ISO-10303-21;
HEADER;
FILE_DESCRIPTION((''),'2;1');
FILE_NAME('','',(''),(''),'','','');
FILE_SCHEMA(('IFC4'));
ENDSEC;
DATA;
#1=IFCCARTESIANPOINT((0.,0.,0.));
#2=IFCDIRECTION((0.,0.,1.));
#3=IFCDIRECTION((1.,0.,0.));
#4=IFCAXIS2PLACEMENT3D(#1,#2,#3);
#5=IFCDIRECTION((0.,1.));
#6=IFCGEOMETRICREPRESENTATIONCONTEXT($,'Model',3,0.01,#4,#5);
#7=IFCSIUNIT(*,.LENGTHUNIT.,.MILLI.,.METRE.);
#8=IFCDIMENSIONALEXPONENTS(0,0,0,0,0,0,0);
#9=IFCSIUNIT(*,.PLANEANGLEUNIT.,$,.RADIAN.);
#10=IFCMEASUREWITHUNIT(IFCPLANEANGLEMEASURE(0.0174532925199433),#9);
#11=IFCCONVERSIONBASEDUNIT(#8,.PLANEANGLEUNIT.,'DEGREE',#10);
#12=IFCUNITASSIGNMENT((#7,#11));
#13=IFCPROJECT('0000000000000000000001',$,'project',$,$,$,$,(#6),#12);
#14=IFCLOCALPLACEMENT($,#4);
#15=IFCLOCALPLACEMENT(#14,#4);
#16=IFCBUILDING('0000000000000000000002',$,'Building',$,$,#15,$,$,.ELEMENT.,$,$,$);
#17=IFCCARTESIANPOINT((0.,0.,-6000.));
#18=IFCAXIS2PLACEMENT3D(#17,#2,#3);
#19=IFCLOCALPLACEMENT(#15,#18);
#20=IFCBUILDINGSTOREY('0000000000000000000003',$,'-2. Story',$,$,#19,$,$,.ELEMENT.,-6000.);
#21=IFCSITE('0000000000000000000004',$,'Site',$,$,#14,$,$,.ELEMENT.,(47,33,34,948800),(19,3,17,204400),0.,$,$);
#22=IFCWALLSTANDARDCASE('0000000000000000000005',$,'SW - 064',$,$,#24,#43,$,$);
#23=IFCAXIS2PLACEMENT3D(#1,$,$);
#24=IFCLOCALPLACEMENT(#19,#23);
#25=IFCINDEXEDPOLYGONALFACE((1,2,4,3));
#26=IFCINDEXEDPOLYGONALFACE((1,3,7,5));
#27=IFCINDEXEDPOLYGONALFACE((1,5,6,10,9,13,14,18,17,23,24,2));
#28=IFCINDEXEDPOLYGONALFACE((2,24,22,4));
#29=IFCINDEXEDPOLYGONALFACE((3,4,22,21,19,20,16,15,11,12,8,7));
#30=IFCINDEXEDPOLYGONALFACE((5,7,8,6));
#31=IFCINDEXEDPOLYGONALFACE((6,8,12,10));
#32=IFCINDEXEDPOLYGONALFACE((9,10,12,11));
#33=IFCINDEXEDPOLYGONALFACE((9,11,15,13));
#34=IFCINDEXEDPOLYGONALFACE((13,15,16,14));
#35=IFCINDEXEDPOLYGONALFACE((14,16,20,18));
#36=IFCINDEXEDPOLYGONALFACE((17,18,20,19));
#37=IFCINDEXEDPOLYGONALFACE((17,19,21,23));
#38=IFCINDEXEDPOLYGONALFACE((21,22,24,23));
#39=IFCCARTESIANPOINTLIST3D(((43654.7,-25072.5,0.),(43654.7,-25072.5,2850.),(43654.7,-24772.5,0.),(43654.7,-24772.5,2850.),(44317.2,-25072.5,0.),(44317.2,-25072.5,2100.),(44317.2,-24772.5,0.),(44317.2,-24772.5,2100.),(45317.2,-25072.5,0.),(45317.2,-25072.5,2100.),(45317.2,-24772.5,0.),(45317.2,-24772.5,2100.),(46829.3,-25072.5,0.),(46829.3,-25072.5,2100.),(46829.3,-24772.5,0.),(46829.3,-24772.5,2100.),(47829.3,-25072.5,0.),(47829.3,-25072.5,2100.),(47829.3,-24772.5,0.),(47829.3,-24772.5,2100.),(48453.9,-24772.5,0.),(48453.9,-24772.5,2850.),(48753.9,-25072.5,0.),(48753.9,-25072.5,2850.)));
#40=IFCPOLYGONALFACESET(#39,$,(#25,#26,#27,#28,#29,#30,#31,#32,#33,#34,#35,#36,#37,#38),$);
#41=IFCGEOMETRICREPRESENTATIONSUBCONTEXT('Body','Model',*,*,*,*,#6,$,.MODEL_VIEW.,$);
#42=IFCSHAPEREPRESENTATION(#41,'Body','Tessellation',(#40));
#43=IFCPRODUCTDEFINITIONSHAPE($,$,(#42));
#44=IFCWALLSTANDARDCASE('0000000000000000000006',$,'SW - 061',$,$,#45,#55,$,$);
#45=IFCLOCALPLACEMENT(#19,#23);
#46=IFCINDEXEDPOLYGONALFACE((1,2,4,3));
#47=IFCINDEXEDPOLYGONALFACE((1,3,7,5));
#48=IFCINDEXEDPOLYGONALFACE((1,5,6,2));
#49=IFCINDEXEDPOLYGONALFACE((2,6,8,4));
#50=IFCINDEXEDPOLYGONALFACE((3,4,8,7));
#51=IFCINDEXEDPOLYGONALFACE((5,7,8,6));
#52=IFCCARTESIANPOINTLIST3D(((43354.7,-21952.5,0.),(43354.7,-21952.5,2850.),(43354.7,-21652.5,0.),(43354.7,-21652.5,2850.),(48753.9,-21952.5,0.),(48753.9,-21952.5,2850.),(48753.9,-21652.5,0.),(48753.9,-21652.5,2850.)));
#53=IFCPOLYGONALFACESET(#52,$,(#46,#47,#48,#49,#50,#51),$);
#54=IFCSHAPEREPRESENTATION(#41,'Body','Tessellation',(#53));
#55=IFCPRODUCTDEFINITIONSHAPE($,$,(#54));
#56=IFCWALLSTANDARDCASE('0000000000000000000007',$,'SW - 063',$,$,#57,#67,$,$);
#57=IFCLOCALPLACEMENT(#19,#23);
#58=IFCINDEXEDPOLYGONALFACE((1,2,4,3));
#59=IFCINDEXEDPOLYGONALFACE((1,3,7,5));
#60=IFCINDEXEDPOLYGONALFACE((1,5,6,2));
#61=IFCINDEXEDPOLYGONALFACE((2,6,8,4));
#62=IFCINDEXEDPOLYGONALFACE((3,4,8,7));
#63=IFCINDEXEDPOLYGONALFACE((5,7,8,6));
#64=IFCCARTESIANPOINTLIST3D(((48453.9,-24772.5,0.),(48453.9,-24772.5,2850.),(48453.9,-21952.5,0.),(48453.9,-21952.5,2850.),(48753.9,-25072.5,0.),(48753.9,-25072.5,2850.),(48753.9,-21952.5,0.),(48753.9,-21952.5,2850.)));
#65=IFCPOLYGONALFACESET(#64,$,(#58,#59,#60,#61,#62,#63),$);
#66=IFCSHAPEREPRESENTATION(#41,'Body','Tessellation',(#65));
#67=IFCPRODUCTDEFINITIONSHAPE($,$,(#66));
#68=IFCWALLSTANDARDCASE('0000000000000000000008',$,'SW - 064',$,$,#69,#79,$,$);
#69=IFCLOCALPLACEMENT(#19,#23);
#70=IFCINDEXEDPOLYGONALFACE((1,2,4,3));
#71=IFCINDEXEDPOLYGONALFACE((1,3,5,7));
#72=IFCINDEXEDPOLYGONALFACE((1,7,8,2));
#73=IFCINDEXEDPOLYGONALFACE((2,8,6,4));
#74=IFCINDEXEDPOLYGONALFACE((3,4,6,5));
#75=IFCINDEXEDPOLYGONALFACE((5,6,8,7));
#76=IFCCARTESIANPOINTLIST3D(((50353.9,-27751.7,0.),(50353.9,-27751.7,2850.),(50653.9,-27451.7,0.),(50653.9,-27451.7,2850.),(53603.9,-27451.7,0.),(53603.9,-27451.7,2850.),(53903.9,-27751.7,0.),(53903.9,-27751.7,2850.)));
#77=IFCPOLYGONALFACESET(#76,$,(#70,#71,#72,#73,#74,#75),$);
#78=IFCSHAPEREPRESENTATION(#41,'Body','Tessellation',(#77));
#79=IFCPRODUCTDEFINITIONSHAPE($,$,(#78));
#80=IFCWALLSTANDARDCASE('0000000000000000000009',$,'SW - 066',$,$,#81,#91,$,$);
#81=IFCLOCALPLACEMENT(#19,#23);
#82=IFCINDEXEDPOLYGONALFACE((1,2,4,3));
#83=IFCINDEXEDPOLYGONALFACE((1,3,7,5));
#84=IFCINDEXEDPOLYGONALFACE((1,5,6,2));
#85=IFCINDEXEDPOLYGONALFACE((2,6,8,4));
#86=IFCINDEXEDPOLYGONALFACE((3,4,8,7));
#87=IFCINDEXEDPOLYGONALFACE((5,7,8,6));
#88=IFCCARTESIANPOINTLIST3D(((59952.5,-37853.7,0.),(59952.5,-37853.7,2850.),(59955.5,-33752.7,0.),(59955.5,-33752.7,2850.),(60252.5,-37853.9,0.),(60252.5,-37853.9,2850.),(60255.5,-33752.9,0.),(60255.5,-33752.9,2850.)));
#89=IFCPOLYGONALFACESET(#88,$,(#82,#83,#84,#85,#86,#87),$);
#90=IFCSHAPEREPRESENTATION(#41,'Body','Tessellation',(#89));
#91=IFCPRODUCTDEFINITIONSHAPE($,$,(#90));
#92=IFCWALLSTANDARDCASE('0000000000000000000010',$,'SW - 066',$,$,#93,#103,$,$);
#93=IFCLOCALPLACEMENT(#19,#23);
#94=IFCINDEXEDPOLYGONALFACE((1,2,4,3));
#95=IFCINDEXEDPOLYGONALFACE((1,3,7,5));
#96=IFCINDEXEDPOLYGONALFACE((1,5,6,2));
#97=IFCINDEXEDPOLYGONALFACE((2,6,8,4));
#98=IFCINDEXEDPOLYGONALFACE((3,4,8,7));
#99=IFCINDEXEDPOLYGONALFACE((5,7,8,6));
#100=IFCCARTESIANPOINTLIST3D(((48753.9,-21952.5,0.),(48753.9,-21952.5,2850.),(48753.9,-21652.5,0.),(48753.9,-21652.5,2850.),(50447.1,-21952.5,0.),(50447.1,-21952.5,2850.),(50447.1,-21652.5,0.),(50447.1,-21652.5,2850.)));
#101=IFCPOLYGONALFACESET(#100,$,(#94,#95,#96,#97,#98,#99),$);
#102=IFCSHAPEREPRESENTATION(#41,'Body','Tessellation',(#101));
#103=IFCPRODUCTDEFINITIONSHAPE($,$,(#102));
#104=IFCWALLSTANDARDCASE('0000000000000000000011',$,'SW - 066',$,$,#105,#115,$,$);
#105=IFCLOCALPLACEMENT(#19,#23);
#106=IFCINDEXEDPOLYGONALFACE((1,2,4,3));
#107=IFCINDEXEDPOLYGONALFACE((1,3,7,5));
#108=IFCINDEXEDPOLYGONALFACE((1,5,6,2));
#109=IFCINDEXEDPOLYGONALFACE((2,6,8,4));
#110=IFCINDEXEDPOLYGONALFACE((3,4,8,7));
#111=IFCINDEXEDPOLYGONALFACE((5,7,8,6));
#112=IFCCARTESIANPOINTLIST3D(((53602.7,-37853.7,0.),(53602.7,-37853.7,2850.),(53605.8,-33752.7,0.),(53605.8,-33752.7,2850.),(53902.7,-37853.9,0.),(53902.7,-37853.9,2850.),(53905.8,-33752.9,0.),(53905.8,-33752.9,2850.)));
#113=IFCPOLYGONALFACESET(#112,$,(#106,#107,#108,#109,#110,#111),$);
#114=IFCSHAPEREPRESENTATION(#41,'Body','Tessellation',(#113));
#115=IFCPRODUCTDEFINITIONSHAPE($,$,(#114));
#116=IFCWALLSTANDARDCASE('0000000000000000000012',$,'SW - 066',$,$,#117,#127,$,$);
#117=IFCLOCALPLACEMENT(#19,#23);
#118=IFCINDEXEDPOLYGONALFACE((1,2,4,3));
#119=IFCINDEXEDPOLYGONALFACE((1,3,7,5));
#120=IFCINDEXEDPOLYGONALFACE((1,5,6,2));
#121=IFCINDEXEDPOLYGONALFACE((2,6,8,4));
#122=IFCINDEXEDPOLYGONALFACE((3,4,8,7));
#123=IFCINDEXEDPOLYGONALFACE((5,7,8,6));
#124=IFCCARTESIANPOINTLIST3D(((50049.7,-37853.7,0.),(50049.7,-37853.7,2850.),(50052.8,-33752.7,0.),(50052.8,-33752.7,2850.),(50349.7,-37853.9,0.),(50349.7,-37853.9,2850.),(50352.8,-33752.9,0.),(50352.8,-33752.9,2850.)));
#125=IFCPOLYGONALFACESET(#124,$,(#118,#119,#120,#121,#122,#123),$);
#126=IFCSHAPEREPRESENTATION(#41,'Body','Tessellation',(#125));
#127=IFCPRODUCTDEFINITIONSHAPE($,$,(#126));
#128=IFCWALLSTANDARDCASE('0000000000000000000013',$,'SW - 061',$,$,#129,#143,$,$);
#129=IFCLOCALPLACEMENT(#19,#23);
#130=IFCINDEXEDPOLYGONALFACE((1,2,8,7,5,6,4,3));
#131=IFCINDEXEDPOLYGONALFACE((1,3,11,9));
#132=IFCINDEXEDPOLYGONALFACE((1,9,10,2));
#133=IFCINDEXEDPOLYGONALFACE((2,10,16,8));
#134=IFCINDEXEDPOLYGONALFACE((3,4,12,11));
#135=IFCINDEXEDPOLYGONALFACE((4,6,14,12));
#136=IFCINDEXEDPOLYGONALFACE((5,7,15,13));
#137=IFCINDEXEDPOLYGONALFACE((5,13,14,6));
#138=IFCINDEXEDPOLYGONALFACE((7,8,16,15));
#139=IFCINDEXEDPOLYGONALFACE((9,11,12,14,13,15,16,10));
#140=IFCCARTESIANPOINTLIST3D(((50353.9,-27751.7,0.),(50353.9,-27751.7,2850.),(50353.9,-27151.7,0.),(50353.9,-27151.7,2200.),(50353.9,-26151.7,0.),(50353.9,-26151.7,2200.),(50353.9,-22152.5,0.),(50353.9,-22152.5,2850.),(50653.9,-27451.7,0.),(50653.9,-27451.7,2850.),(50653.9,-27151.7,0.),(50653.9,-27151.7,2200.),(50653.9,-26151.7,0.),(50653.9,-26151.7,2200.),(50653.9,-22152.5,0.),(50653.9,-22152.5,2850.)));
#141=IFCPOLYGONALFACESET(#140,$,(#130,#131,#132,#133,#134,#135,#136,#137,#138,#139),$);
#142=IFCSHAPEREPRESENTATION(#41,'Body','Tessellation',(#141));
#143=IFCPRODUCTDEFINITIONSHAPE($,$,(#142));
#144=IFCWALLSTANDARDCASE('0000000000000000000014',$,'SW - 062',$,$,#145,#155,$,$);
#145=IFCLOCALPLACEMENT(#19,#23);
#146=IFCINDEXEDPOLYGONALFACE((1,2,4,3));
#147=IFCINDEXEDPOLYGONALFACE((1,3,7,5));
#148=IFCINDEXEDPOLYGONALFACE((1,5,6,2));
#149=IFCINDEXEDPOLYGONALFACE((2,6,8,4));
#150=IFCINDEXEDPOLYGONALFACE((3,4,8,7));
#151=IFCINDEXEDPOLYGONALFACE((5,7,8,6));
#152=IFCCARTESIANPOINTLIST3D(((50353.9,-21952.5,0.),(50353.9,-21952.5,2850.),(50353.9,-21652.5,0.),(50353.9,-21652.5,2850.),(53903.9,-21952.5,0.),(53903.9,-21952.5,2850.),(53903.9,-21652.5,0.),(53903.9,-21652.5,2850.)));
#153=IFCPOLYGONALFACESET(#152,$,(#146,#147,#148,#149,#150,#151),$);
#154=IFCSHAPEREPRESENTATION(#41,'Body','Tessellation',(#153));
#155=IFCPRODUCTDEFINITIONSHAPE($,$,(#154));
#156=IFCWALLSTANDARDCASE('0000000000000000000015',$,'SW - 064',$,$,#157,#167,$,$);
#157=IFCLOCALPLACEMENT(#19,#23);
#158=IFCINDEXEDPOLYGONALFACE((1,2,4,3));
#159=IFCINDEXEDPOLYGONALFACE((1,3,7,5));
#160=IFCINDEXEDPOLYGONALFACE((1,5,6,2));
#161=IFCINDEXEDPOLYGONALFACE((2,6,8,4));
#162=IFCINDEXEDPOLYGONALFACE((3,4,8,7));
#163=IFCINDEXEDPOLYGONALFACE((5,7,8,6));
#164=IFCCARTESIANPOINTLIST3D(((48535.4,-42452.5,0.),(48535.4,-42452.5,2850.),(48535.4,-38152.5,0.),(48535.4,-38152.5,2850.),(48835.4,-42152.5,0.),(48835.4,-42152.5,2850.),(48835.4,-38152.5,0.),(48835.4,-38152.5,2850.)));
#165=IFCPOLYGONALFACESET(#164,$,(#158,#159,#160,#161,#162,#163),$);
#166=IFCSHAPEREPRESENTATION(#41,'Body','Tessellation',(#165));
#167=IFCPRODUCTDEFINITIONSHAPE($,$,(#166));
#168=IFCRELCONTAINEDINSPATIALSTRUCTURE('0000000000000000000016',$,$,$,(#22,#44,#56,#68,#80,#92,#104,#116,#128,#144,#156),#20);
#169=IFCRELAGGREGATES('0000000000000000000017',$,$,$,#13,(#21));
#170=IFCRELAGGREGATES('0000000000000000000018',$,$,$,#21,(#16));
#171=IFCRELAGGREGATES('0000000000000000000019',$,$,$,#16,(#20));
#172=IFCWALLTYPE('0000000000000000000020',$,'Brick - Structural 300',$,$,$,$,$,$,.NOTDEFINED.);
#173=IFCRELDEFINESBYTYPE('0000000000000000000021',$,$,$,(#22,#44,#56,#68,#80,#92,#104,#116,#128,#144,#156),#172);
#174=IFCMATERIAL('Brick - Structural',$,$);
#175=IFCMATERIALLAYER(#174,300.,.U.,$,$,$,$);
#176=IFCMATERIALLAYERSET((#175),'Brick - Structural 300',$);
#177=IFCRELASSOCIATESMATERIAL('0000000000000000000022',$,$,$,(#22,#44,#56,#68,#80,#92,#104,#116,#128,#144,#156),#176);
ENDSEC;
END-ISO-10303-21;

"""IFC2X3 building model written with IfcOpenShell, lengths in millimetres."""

from ifc_helpers import new_model, entity, si_unit, converted_unit, direction, frame, origin_with_axes, origin_2d_with_axis, place, context, subcontext, project, spatial, polyline, rectangle, outline, extrude, material, layer, layer_set, layer_usage, type_object, element, save


model = new_model("IFC2X3")

# Units and contexts
model_context = context("Model", 3, precision=0.01, world=origin_with_axes(), true_north=direction((0.0, 1.0)))
body_context = subcontext(model_context, "Body", "Model", "MODEL_VIEW")
ifc_project = project(units=[si_unit("LENGTHUNIT", "METRE", prefix="MILLI"), converted_unit("PLANEANGLEUNIT", "DEGREE", entity("IfcPlaneAngleMeasure", 0.0174532925199433), si_unit("PLANEANGLEUNIT", "RADIAN"), dimensions=[0, 0, 0, 0, 0, 0, 0])], contexts=[model_context])

# Site, building, storey
site_placement = place(None, origin_with_axes())
site = spatial("IfcSite", under=ifc_project, at=site_placement, Name="Site", CompositionType="ELEMENT", RefLatitude=(47, 33, 34, 948800), RefLongitude=(19, 3, 17, 204400), RefElevation=0.0)
building_placement = place(site_placement, origin_with_axes())
building = spatial("IfcBuilding", under=site, at=building_placement, Name="Building", CompositionType="ELEMENT")
storey_placement = place(building_placement, frame((0.0, 0.0, -6000.0), z_axis=(0.0, 0.0, 1.0), x_axis=(1.0, 0.0, 0.0)))
storey = spatial("IfcBuildingStorey", under=building, at=storey_placement, Name="-2. Story", CompositionType="ELEMENT", Elevation=-6000.0)

# Shared definitions
ifc_material_1 = material(Name="Brick - Structural")
ifc_layer_1 = layer(ifc_material_1, 300.0, ventilated="UNKNOWN")
ifc_layer_set_1 = layer_set([ifc_layer_1], Name="Brick - Structural 300")
wall_type_1 = type_object("IfcWallType", Name="Brick - Structural 300", PredefinedType="NOTDEFINED")

# Wall, openings
ifc_layer_usage_1 = layer_usage(ifc_layer_set_1, "AXIS2", "NEGATIVE", 0.0)
wall_1_placement = place(storey_placement, frame((48753.9, -25072.5, 0.0), z_axis=(0.0, 0.0, 1.0), x_axis=(-1.0, 0.0, 0.0)))
wall_1 = element("IfcWallStandardCase", 1, at=wall_1_placement, inside=storey, type_object=wall_type_1, material=ifc_layer_usage_1, Name="SW - 064", context=body_context, shape_type="SweptSolid", body=[
    extrude(outline(polyline([(300.0, -300.0), (5099.2, -300.0), (5099.2, 0.0), (0.0, 0.0), (300.0, -300.0)])), origin_with_axes(), (0.0, 0.0, 1.0), 2850.0),
])
opening_1_placement = place(wall_1_placement, frame((3936.7, 0.0, 0.0), z_axis=(0.0, 0.0, 1.0), x_axis=(1.0, 0.0, 0.0)))
element("IfcOpeningElement", 2, at=opening_1_placement, cuts=wall_1, context=body_context, shape_type="SweptSolid", body=[
    extrude(rectangle(XDim=1000.0, YDim=2100.0, at=origin_2d_with_axis()), frame((0.0, 0.0, 1050.0), z_axis=(0.0, -1.0, 0.0), x_axis=(1.0, 0.0, 0.0)), (0.0, 0.0, -1.0), 300.0),
    extrude(rectangle(XDim=1000.0, YDim=2100.0, at=origin_2d_with_axis()), frame((0.0, 0.0, 1050.0), z_axis=(0.0, 1.0, 0.0), x_axis=(1.0, 0.0, 0.0)), (0.0, 0.0, -1.0), 300.0),
])
opening_2_placement = place(wall_1_placement, frame((1424.6, 0.0, 0.0), z_axis=(0.0, 0.0, 1.0), x_axis=(1.0, 0.0, 0.0)))
element("IfcOpeningElement", 3, at=opening_2_placement, cuts=wall_1, context=body_context, shape_type="SweptSolid", body=[
    extrude(rectangle(XDim=1000.0, YDim=2100.0, at=origin_2d_with_axis()), frame((0.0, 0.0, 1050.0), z_axis=(0.0, -1.0, 0.0), x_axis=(1.0, 0.0, 0.0)), (0.0, 0.0, -1.0), 300.0),
    extrude(rectangle(XDim=1000.0, YDim=2100.0, at=origin_2d_with_axis()), frame((0.0, 0.0, 1050.0), z_axis=(0.0, 1.0, 0.0), x_axis=(1.0, 0.0, 0.0)), (0.0, 0.0, -1.0), 300.0),
])

# Walls
ifc_layer_usage_2 = layer_usage(ifc_layer_set_1, "AXIS2", "POSITIVE", 0.0)
wall_2_placement = place(storey_placement, frame((48753.9, -21652.5, 0.0), z_axis=(0.0, 0.0, 1.0), x_axis=(-1.0, 0.0, 0.0)))
element("IfcWallStandardCase", 4, at=wall_2_placement, inside=storey, type_object=wall_type_1, material=ifc_layer_usage_2, Name="SW - 061", context=body_context, shape_type="SweptSolid", body=[
    extrude(outline(polyline([(0.0, 0.0), (5399.2, 0.0), (5399.2, 300.0), (0.0, 300.0), (0.0, 0.0)])), origin_with_axes(), (0.0, 0.0, 1.0), 2850.0),
])
ifc_layer_usage_3 = layer_usage(ifc_layer_set_1, "AXIS2", "NEGATIVE", 0.0)
wall_3_placement = place(storey_placement, frame((48753.9, -21652.5, 0.0), z_axis=(0.0, 0.0, 1.0), x_axis=(0.0, -1.0, 0.0)))
element("IfcWallStandardCase", 5, at=wall_3_placement, inside=storey, type_object=wall_type_1, material=ifc_layer_usage_3, Name="SW - 063", context=body_context, shape_type="SweptSolid", body=[
    extrude(outline(polyline([(300.0, -300.0), (3120.0, -300.0), (3420.0, 0.0), (300.0, 0.0), (300.0, -300.0)])), origin_with_axes(), (0.0, 0.0, 1.0), 2850.0),
])
ifc_layer_usage_4 = layer_usage(ifc_layer_set_1, "AXIS2", "NEGATIVE", 0.0)
wall_4_placement = place(storey_placement, frame((53903.9, -27751.7, 0.0), z_axis=(0.0, 0.0, 1.0), x_axis=(-1.0, 0.0, 0.0)))
element("IfcWallStandardCase", 6, at=wall_4_placement, inside=storey, type_object=wall_type_1, material=ifc_layer_usage_4, Name="SW - 064", context=body_context, shape_type="SweptSolid", body=[
    extrude(outline(polyline([(300.0, -300.0), (3250.0, -300.0), (3550.0, 0.0), (0.0, 0.0), (300.0, -300.0)])), origin_with_axes(), (0.0, 0.0, 1.0), 2850.0),
])
ifc_layer_usage_5 = layer_usage(ifc_layer_set_1, "AXIS2", "POSITIVE", 0.0)
wall_5_placement = place(storey_placement, frame((59955.5, -33752.7, 0.0), z_axis=(0.0, 0.0, 1.0), x_axis=(-0.000749, -1.0, 0.0)))
element("IfcWallStandardCase", 7, at=wall_5_placement, inside=storey, type_object=wall_type_1, material=ifc_layer_usage_5, Name="SW - 066", context=body_context, shape_type="SweptSolid", body=[
    extrude(outline(polyline([(0.0, 0.0), (4101.0, 0.0), (4101.0, 300.0), (0.0, 300.0), (0.0, 0.0)])), origin_with_axes(), (0.0, 0.0, 1.0), 2850.0),
])
ifc_layer_usage_6 = layer_usage(ifc_layer_set_1, "AXIS2", "POSITIVE", 0.0)
wall_6_placement = place(storey_placement, frame((50447.1, -21652.5, 0.0), z_axis=(0.0, 0.0, 1.0), x_axis=(-1.0, 0.0, 0.0)))
element("IfcWallStandardCase", 8, at=wall_6_placement, inside=storey, type_object=wall_type_1, material=ifc_layer_usage_6, Name="SW - 066", context=body_context, shape_type="SweptSolid", body=[
    extrude(outline(polyline([(0.0, 0.0), (1693.2, 0.0), (1693.2, 300.0), (0.0, 300.0), (0.0, 0.0)])), origin_with_axes(), (0.0, 0.0, 1.0), 2850.0),
])
ifc_layer_usage_7 = layer_usage(ifc_layer_set_1, "AXIS2", "POSITIVE", 0.0)
wall_7_placement = place(storey_placement, frame((53605.8, -33752.7, 0.0), z_axis=(0.0, 0.0, 1.0), x_axis=(-0.000749, -1.0, 0.0)))
element("IfcWallStandardCase", 9, at=wall_7_placement, inside=storey, type_object=wall_type_1, material=ifc_layer_usage_7, Name="SW - 066", context=body_context, shape_type="SweptSolid", body=[
    extrude(outline(polyline([(0.0, 0.0), (4101.0, 0.0), (4101.0, 300.0), (0.0, 300.0), (0.0, 0.0)])), origin_with_axes(), (0.0, 0.0, 1.0), 2850.0),
])
ifc_layer_usage_8 = layer_usage(ifc_layer_set_1, "AXIS2", "POSITIVE", 0.0)
wall_8_placement = place(storey_placement, frame((50052.8, -33752.7, 0.0), z_axis=(0.0, 0.0, 1.0), x_axis=(-0.000749, -1.0, 0.0)))
element("IfcWallStandardCase", 10, at=wall_8_placement, inside=storey, type_object=wall_type_1, material=ifc_layer_usage_8, Name="SW - 066", context=body_context, shape_type="SweptSolid", body=[
    extrude(outline(polyline([(0.0, 0.0), (4101.0, 0.0), (4101.0, 300.0), (0.0, 300.0), (0.0, 0.0)])), origin_with_axes(), (0.0, 0.0, 1.0), 2850.0),
])

# Wall, opening
ifc_layer_usage_9 = layer_usage(ifc_layer_set_1, "AXIS2", "NEGATIVE", 0.0)
wall_9_placement = place(storey_placement, frame((50353.9, -27751.7, 0.0), z_axis=(0.0, 0.0, 1.0), x_axis=(0.0, 1.0, 0.0)))
wall_9 = element("IfcWallStandardCase", 11, at=wall_9_placement, inside=storey, type_object=wall_type_1, material=ifc_layer_usage_9, Name="SW - 061", context=body_context, shape_type="SweptSolid", body=[
    extrude(outline(polyline([(300.0, -300.0), (5599.2, -300.0), (5599.2, 0.0), (0.0, 0.0), (300.0, -300.0)])), origin_with_axes(), (0.0, 0.0, 1.0), 2850.0),
])
opening_3_placement = place(wall_9_placement, frame((1100.0, 0.0, 0.0), z_axis=(0.0, 0.0, 1.0), x_axis=(1.0, 0.0, 0.0)))
element("IfcOpeningElement", 12, at=opening_3_placement, cuts=wall_9, context=body_context, shape_type="SweptSolid", body=[
    extrude(rectangle(XDim=1000.0, YDim=2200.0, at=origin_2d_with_axis()), frame((0.0, -300.0, 1100.0), z_axis=(0.0, 1.0, 0.0), x_axis=(1.0, 0.0, 0.0)), (0.0, 0.0, -1.0), 300.0),
    extrude(rectangle(XDim=1000.0, YDim=2200.0, at=origin_2d_with_axis()), frame((0.0, -300.0, 1100.0), z_axis=(0.0, -1.0, 0.0), x_axis=(1.0, 0.0, 0.0)), (0.0, 0.0, -1.0), 300.0),
])

# Walls
ifc_layer_usage_10 = layer_usage(ifc_layer_set_1, "AXIS2", "NEGATIVE", 0.0)
wall_10_placement = place(storey_placement, frame((50353.9, -21652.5, 0.0), z_axis=(0.0, 0.0, 1.0), x_axis=(1.0, 0.0, 0.0)))
element("IfcWallStandardCase", 13, at=wall_10_placement, inside=storey, type_object=wall_type_1, material=ifc_layer_usage_10, Name="SW - 062", context=body_context, shape_type="SweptSolid", body=[
    extrude(outline(polyline([(0.0, -300.0), (3550.0, -300.0), (3550.0, 0.0), (0.0, 0.0), (0.0, -300.0)])), origin_with_axes(), (0.0, 0.0, 1.0), 2850.0),
])
ifc_layer_usage_11 = layer_usage(ifc_layer_set_1, "AXIS2", "POSITIVE", 0.0)
wall_11_placement = place(storey_placement, frame((48835.4, -42152.5, 0.0), z_axis=(0.0, 0.0, 1.0), x_axis=(0.0, 1.0, 0.0)))
element("IfcWallStandardCase", 14, at=wall_11_placement, inside=storey, type_object=wall_type_1, material=ifc_layer_usage_11, Name="SW - 064", context=body_context, shape_type="SweptSolid", body=[
    extrude(outline(polyline([(0.0, 0.0), (4000.0, 0.0), (4000.0, 300.0), (-300.0, 300.0), (0.0, 0.0)])), origin_with_axes(), (0.0, 0.0, 1.0), 2850.0),
])

save(model, "model.ifc")
